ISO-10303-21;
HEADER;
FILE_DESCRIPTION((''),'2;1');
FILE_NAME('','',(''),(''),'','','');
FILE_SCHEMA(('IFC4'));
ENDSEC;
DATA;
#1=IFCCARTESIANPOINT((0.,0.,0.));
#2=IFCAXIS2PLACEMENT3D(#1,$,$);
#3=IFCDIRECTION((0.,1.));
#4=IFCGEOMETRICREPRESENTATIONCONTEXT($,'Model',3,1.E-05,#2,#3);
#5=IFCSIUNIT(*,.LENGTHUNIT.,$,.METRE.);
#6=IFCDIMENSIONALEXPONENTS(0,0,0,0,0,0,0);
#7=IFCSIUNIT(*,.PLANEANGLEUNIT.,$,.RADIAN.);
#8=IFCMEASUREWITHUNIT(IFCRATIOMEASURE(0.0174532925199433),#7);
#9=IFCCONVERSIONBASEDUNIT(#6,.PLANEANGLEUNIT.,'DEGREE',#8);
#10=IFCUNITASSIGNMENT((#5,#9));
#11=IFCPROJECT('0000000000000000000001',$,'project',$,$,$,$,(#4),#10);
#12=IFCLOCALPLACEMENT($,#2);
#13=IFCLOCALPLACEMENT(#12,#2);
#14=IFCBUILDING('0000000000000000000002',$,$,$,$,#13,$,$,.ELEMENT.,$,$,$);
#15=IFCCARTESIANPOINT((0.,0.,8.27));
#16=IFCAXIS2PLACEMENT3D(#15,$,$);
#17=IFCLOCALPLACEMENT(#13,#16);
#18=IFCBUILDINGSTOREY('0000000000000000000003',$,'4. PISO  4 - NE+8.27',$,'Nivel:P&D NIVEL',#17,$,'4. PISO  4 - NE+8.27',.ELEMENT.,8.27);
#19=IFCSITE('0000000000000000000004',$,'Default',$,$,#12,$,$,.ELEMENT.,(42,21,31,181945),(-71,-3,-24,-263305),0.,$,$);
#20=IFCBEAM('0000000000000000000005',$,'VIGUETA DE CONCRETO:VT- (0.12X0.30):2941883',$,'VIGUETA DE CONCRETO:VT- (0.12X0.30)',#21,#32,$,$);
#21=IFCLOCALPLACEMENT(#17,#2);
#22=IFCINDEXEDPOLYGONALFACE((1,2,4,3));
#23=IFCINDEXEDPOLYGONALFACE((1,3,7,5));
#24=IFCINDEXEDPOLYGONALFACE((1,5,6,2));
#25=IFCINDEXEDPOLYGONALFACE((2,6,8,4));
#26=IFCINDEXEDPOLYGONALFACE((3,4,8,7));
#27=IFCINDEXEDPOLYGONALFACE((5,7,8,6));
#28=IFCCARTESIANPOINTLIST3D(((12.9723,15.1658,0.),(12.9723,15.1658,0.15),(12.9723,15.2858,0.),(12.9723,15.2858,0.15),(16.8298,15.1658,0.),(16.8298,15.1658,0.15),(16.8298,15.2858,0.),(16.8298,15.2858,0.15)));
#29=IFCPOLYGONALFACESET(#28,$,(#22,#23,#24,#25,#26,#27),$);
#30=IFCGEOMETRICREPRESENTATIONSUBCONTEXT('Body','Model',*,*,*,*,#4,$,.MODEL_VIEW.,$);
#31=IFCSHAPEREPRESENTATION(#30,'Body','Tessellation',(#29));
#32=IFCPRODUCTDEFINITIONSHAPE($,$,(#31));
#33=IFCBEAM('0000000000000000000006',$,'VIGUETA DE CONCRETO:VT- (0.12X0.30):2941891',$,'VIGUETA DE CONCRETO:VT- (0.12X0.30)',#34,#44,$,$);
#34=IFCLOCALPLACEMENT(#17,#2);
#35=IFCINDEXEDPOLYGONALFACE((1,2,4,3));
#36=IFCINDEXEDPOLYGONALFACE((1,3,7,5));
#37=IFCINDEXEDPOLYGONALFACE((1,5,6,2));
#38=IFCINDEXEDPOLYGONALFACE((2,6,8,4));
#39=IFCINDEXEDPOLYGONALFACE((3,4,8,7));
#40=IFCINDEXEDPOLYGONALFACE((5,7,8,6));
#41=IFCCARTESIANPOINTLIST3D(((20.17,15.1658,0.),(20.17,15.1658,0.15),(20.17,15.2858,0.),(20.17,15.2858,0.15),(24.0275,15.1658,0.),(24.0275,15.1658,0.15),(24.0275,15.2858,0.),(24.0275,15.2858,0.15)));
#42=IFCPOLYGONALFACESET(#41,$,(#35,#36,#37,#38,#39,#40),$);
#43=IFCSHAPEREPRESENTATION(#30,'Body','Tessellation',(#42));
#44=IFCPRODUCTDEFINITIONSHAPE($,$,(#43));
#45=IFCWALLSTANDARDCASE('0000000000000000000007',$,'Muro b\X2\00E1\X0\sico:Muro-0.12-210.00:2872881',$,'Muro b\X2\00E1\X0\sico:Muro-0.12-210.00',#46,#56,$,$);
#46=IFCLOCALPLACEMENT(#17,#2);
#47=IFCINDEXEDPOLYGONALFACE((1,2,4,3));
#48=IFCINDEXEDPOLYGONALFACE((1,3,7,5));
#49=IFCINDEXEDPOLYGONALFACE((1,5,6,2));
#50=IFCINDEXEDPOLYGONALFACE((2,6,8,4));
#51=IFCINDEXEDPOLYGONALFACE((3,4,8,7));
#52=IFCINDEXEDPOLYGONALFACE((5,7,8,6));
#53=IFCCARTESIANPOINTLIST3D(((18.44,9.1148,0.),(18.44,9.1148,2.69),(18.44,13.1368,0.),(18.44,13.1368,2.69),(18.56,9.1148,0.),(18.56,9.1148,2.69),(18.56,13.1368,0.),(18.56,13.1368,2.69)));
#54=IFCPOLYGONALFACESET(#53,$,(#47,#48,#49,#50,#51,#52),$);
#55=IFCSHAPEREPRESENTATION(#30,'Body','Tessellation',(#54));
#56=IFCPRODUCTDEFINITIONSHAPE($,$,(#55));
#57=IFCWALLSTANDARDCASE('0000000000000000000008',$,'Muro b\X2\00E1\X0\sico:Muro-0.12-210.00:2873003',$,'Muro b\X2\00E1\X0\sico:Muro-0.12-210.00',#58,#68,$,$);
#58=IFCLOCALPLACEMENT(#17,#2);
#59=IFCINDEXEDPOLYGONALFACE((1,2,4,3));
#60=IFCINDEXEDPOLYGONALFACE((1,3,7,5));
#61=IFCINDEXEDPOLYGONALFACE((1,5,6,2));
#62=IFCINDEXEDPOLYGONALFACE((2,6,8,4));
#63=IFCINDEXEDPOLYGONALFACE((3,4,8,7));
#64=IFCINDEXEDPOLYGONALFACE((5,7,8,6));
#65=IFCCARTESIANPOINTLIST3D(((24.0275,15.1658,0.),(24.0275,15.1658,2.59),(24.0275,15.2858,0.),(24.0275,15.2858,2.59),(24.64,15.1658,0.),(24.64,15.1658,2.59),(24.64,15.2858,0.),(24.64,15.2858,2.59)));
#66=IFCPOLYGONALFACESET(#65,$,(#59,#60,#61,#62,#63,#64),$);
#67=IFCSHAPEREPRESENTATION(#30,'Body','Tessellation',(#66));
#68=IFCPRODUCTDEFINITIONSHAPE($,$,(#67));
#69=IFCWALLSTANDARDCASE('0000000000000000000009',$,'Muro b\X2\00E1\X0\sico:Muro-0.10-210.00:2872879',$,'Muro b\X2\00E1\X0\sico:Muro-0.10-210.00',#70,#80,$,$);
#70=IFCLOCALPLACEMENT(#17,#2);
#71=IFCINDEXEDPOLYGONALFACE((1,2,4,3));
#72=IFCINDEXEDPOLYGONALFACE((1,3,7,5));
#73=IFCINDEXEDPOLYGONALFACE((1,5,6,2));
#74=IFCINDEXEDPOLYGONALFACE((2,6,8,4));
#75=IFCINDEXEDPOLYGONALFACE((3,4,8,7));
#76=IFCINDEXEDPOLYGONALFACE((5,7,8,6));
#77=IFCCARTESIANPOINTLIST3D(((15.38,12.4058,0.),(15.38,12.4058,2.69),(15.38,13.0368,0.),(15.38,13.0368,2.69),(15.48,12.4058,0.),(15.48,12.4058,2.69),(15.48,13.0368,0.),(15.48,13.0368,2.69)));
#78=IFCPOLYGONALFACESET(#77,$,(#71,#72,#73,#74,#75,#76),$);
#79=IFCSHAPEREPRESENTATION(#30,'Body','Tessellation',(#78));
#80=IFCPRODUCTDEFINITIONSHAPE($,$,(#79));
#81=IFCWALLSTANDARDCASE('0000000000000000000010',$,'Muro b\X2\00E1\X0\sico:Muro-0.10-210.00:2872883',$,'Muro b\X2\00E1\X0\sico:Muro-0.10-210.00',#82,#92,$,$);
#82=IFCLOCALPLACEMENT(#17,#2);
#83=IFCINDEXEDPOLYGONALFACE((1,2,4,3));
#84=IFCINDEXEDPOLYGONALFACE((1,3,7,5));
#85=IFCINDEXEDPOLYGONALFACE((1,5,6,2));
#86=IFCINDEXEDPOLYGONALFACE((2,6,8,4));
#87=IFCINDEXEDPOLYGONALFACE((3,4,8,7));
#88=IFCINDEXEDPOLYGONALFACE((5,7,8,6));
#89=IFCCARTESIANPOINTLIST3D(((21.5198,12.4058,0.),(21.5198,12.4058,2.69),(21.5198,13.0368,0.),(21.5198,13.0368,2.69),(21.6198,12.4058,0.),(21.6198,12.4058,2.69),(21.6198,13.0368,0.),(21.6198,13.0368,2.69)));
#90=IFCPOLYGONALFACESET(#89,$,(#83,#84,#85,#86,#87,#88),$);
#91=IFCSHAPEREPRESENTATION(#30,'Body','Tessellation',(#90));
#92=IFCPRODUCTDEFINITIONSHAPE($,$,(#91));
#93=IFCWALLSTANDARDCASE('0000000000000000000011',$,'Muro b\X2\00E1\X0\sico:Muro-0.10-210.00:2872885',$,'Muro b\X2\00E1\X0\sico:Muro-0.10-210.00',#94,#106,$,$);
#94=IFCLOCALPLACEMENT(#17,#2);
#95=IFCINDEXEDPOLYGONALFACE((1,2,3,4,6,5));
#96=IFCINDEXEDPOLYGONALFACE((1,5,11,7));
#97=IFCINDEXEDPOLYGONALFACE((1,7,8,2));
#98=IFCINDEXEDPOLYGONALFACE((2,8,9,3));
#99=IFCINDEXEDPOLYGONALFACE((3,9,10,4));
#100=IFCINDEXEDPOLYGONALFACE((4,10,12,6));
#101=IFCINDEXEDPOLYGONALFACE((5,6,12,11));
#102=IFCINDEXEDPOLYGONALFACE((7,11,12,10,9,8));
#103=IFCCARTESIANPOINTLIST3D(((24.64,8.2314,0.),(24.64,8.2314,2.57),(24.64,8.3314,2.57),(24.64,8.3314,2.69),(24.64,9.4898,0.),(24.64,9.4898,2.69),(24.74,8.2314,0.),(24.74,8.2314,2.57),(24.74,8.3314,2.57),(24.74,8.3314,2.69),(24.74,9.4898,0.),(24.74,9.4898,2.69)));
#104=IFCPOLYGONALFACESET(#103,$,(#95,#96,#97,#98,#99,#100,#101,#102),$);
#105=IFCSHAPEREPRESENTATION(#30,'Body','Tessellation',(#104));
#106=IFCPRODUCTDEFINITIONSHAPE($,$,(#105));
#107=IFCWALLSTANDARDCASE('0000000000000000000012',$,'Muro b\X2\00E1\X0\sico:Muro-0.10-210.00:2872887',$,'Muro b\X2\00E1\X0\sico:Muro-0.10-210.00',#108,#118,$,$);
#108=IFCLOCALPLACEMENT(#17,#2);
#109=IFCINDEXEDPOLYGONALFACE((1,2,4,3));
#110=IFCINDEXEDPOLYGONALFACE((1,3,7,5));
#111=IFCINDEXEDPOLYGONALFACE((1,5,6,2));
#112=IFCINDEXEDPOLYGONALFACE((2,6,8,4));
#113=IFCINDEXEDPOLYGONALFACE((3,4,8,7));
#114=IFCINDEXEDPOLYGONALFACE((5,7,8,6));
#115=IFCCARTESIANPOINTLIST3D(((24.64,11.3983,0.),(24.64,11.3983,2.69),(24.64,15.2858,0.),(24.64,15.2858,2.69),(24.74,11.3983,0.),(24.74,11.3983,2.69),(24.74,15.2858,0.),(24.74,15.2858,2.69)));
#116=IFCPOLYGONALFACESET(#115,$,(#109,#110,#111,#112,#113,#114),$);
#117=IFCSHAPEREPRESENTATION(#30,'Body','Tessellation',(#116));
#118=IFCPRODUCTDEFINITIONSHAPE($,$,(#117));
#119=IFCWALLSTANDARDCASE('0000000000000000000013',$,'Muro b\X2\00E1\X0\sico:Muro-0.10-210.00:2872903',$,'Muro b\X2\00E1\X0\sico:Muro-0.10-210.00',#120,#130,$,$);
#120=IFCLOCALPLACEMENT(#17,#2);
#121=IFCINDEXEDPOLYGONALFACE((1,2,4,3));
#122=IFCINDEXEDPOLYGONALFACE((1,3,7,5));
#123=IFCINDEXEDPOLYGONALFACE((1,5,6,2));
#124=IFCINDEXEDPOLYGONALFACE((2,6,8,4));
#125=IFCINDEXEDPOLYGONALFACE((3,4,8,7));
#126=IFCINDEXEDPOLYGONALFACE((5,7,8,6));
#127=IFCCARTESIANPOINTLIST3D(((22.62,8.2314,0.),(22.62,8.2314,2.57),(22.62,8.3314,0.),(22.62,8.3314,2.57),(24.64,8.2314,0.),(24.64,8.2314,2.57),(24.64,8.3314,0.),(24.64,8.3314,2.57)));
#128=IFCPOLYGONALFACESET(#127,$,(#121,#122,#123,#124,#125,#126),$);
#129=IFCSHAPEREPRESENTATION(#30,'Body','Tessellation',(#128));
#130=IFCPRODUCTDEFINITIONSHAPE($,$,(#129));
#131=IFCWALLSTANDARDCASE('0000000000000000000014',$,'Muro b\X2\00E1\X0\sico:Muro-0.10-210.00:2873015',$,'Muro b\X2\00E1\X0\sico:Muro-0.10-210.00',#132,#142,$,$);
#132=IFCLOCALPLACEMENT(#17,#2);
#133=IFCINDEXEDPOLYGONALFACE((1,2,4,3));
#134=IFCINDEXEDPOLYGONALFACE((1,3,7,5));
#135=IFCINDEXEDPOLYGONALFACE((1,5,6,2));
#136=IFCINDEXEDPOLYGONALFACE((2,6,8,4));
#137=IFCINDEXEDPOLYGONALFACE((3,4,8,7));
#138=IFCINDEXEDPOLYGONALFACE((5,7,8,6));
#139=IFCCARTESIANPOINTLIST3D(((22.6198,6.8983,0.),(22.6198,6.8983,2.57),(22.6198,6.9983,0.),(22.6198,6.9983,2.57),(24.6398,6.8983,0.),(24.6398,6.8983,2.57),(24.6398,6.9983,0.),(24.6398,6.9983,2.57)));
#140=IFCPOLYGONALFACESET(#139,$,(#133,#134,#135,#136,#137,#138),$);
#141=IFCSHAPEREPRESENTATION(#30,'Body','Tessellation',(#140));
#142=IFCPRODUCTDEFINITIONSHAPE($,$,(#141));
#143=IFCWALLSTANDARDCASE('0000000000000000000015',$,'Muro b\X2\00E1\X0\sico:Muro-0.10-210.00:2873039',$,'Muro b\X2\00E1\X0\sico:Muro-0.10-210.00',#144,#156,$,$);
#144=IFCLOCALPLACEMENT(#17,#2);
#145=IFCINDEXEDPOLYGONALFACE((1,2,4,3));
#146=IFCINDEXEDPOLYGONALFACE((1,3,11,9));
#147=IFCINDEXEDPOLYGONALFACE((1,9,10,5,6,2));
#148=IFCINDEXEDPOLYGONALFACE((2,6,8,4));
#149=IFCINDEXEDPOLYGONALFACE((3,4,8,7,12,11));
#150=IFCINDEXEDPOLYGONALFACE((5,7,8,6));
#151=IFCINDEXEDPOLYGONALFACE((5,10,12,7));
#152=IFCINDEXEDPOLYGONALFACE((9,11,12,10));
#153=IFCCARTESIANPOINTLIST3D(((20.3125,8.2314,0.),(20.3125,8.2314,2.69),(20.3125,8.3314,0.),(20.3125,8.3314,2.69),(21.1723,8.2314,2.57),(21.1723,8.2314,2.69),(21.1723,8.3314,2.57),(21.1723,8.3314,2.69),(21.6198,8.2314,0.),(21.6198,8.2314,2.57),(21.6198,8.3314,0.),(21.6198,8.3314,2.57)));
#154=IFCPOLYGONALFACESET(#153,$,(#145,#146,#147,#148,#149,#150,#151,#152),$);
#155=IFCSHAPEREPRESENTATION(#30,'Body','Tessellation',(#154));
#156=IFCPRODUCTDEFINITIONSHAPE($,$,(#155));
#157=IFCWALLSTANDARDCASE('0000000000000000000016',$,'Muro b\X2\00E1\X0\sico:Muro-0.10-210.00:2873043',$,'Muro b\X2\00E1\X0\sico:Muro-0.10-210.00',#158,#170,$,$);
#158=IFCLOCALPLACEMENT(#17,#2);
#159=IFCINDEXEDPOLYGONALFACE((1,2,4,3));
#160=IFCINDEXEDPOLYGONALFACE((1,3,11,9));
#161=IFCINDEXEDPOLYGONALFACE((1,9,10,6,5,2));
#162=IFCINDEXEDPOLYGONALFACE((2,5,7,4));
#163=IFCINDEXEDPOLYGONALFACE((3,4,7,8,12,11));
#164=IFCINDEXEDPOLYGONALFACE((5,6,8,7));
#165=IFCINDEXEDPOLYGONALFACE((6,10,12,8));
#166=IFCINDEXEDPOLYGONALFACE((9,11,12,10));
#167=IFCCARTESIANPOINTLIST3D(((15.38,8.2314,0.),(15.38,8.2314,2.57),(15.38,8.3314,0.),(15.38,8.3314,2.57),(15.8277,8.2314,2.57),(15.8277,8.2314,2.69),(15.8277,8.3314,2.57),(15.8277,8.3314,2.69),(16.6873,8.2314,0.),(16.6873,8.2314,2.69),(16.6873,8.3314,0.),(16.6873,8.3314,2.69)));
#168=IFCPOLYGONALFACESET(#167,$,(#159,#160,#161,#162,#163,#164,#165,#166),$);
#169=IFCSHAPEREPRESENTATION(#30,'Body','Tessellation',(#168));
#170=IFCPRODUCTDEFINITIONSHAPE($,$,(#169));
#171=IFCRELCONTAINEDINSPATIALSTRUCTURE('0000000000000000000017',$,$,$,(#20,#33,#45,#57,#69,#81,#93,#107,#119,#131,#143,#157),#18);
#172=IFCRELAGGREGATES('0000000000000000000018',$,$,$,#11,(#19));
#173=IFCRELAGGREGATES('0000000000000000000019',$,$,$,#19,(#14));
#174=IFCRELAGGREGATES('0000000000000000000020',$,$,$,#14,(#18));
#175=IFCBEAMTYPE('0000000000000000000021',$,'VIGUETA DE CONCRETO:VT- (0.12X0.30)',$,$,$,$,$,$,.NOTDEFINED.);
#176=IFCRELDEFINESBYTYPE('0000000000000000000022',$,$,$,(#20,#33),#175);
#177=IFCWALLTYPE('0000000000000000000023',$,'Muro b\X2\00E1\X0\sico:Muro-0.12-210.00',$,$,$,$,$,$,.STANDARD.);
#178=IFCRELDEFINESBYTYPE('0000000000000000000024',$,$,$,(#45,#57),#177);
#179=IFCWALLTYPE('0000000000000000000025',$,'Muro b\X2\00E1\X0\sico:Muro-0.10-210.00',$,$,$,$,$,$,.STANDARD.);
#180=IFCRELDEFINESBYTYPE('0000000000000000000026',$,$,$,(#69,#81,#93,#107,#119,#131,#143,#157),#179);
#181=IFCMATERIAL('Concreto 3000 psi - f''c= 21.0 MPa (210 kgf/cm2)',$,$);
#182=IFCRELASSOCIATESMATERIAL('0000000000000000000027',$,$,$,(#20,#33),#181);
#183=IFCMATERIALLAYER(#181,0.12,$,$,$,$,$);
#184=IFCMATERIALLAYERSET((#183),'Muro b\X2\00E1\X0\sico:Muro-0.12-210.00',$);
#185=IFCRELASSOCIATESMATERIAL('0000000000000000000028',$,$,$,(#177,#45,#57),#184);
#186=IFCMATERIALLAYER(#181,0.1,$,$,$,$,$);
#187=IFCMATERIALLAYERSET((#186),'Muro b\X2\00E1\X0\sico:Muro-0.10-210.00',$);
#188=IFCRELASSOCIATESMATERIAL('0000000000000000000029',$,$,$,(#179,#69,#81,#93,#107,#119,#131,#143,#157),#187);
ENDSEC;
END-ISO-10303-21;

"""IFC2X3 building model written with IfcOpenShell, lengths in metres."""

from ifc_helpers import new_model, entity, si_unit, converted_unit, direction, frame, frame_2d, origin, place, context, subcontext, project, spatial, polyline, rectangle, extrude, clip, bounded_halfspace, material, layer, layer_set, layer_usage, type_object, element, save


model = new_model("IFC2X3")

# Units and contexts
model_context = context("Model", 3, precision=1e-05, world=origin(), true_north=direction((0.0, 1.0)))
body_context = subcontext(model_context, "Body", "Model", "MODEL_VIEW")
ifc_project = project(units=[si_unit("LENGTHUNIT", "METRE"), converted_unit("PLANEANGLEUNIT", "DEGREE", entity("IfcRatioMeasure", 0.0174532925199433), si_unit("PLANEANGLEUNIT", "RADIAN"), dimensions=[0, 0, 0, 0, 0, 0, 0])], contexts=[model_context])

# Site, building, storey
site_placement = place(None, origin())
site = spatial("IfcSite", under=ifc_project, at=site_placement, Name="Default", CompositionType="ELEMENT", RefLatitude=(42, 21, 31, 181945), RefLongitude=(-71, -3, -24, -263305), RefElevation=0.0)
building_placement = place(site_placement, origin())
building = spatial("IfcBuilding", under=site, at=building_placement, CompositionType="ELEMENT")
storey_placement = place(building_placement, frame((0.0, 0.0, 8.27)))
storey = spatial("IfcBuildingStorey", under=building, at=storey_placement, Name="4. PISO  4 - NE+8.27", ObjectType="Nivel:P&D NIVEL", LongName="4. PISO  4 - NE+8.27", CompositionType="ELEMENT", Elevation=8.27)

# Beams
ifc_material = material(Name="Concreto 3000 psi - f'c= 21.0 MPa (210 kgf/cm2)")
beam_type_1 = type_object("IfcBeamType", Name="VIGUETA DE CONCRETO:VT- (0.12X0.30)", PredefinedType="NOTDEFINED")
beam_1_placement = place(storey_placement, frame((16.9048, 15.2258, 0.0), z_axis=(0.0, 0.0, 1.0), x_axis=(-1.0, 0.0, 0.0)))
element("IfcBeam", 1, at=beam_1_placement, inside=storey, type_object=beam_type_1, material=ifc_material, Name="VIGUETA DE CONCRETO:VT- (0.12X0.30):2941883", ObjectType="VIGUETA DE CONCRETO:VT- (0.12X0.30)", context=body_context, shape_type="SweptSolid", body=[
    extrude(rectangle(XDim=0.15, YDim=0.12, at=frame_2d((0.0, 0.0), x_axis=(1.0, 0.0))), frame((0.075, 0.0, 0.075), z_axis=(1.0, 0.0, 0.0), x_axis=(0.0, 0.0, -1.0)), (0.0, 0.0, 1.0), 3.8575),
])
beam_2_placement = place(storey_placement, frame((20.095, 15.2258, 0.0)))
element("IfcBeam", 2, at=beam_2_placement, inside=storey, type_object=beam_type_1, material=ifc_material, Name="VIGUETA DE CONCRETO:VT- (0.12X0.30):2941891", ObjectType="VIGUETA DE CONCRETO:VT- (0.12X0.30)", context=body_context, shape_type="SweptSolid", body=[
    extrude(rectangle(XDim=0.15, YDim=0.12, at=frame_2d((0.0, 0.0), x_axis=(1.0, 0.0))), frame((0.075, 0.0, 0.075), z_axis=(1.0, 0.0, 0.0), x_axis=(0.0, 0.0, -1.0)), (0.0, 0.0, 1.0), 3.8575),
])

# Walls
ifc_layer_1 = layer(ifc_material, 0.12)
ifc_layer_set_1 = layer_set([ifc_layer_1], Name="Muro básico:Muro-0.12-210.00")
ifc_layer_usage_1 = layer_usage(ifc_layer_set_1, "AXIS2", "POSITIVE", -0.06)
wall_type_1 = type_object("IfcWallType", Name="Muro básico:Muro-0.12-210.00", PredefinedType="STANDARD", material=ifc_layer_set_1)
wall_1_placement = place(storey_placement, frame((18.5, 9.1148, 0.0), z_axis=(0.0, 0.0, 1.0), x_axis=(0.0, 1.0, 0.0)))
element("IfcWallStandardCase", 3, at=wall_1_placement, inside=storey, type_object=wall_type_1, material=ifc_layer_usage_1, Name="Muro básico:Muro-0.12-210.00:2872881", ObjectType="Muro básico:Muro-0.12-210.00", context=body_context, shape_type="SweptSolid", body=[
    extrude(rectangle(XDim=4.022, YDim=0.12, at=frame_2d((2.011, 0.0), x_axis=(-1.0, 0.0))), origin(), (0.0, 0.0, 1.0), 2.69),
])
wall_2_placement = place(storey_placement, frame((24.0275, 15.2258, 0.0)))
element("IfcWallStandardCase", 4, at=wall_2_placement, inside=storey, type_object=wall_type_1, material=ifc_layer_usage_1, Name="Muro básico:Muro-0.12-210.00:2873003", ObjectType="Muro básico:Muro-0.12-210.00", context=body_context, shape_type="SweptSolid", body=[
    extrude(rectangle(XDim=0.6125, YDim=0.12, at=frame_2d((0.3062, 0.0), x_axis=(-1.0, 0.0))), origin(), (0.0, 0.0, 1.0), 2.59),
])
ifc_layer_2 = layer(ifc_material, 0.1)
ifc_layer_set_2 = layer_set([ifc_layer_2], Name="Muro básico:Muro-0.10-210.00")
ifc_layer_usage_2 = layer_usage(ifc_layer_set_2, "AXIS2", "POSITIVE", -0.05)
wall_type_2 = type_object("IfcWallType", Name="Muro básico:Muro-0.10-210.00", PredefinedType="STANDARD", material=ifc_layer_set_2)
wall_3_placement = place(storey_placement, frame((15.43, 12.4058, 0.0), z_axis=(0.0, 0.0, 1.0), x_axis=(0.0, 1.0, 0.0)))
element("IfcWallStandardCase", 5, at=wall_3_placement, inside=storey, type_object=wall_type_2, material=ifc_layer_usage_2, Name="Muro básico:Muro-0.10-210.00:2872879", ObjectType="Muro básico:Muro-0.10-210.00", context=body_context, shape_type="SweptSolid", body=[
    extrude(rectangle(XDim=0.631, YDim=0.1, at=frame_2d((0.3155, 0.0), x_axis=(-1.0, 0.0))), origin(), (0.0, 0.0, 1.0), 2.69),
])
wall_4_placement = place(storey_placement, frame((21.5698, 12.4058, 0.0), z_axis=(0.0, 0.0, 1.0), x_axis=(0.0, 1.0, 0.0)))
element("IfcWallStandardCase", 6, at=wall_4_placement, inside=storey, type_object=wall_type_2, material=ifc_layer_usage_2, Name="Muro básico:Muro-0.10-210.00:2872883", ObjectType="Muro básico:Muro-0.10-210.00", context=body_context, shape_type="SweptSolid", body=[
    extrude(rectangle(XDim=0.631, YDim=0.1, at=frame_2d((0.3155, 0.0), x_axis=(-1.0, 0.0))), origin(), (0.0, 0.0, 1.0), 2.69),
])
wall_5_placement = place(storey_placement, frame((24.69, 8.2314, 0.0), z_axis=(0.0, 0.0, 1.0), x_axis=(0.0, 1.0, 0.0)))
element("IfcWallStandardCase", 7, at=wall_5_placement, inside=storey, type_object=wall_type_2, material=ifc_layer_usage_2, Name="Muro básico:Muro-0.10-210.00:2872885", ObjectType="Muro básico:Muro-0.10-210.00", context=body_context, shape_type="Clipping", body=[
    clip(clip(extrude(rectangle(XDim=1.2584, YDim=0.1, at=frame_2d((0.6292, 0.0), x_axis=(-1.0, 0.0))), origin(), (0.0, 0.0, 1.0), 2.69), bounded_halfspace(frame((0.1, -0.05, 2.57), z_axis=(0.0, 0.0, -1.0), x_axis=(-1.0, 0.0, 0.0)), True, frame((0.1, -0.05, 2.57), z_axis=(0.0, 0.0, -1.0), x_axis=(-1.0, 0.0, 0.0)), polyline([(0.0, 0.0), (0.1, 0.0), (0.1, 0.1), (0.0, 0.1), (0.0, 0.0)]))), bounded_halfspace(frame((0.1, 0.05, 2.57), z_axis=(1.0, 0.0, 0.0), x_axis=(0.0, 0.0, 1.0)), True, frame((0.1, 0.05, 2.57), z_axis=(1.0, 0.0, 0.0), x_axis=(0.0, 0.0, 1.0)), polyline([(0.0, 0.0), (0.12, 0.0), (0.12, 0.1), (0.0, 0.1), (0.0, 0.0)]))),
])
wall_6_placement = place(storey_placement, frame((24.69, 11.3983, 0.0), z_axis=(0.0, 0.0, 1.0), x_axis=(0.0, 1.0, 0.0)))
element("IfcWallStandardCase", 8, at=wall_6_placement, inside=storey, type_object=wall_type_2, material=ifc_layer_usage_2, Name="Muro básico:Muro-0.10-210.00:2872887", ObjectType="Muro básico:Muro-0.10-210.00", context=body_context, shape_type="SweptSolid", body=[
    extrude(rectangle(XDim=3.8875, YDim=0.1, at=frame_2d((1.9437, 0.0), x_axis=(-1.0, 0.0))), origin(), (0.0, 0.0, 1.0), 2.69),
])
wall_7_placement = place(storey_placement, frame((22.62, 8.2814, 0.0)))
element("IfcWallStandardCase", 9, at=wall_7_placement, inside=storey, type_object=wall_type_2, material=ifc_layer_usage_2, Name="Muro básico:Muro-0.10-210.00:2872903", ObjectType="Muro básico:Muro-0.10-210.00", context=body_context, shape_type="Clipping", body=[
    clip(extrude(rectangle(XDim=2.02, YDim=0.1, at=frame_2d((1.01, 0.0), x_axis=(-1.0, 0.0))), origin(), (0.0, 0.0, 1.0), 2.57), bounded_halfspace(frame((0.0, -0.05, 2.57), z_axis=(0.0, 0.0, -1.0), x_axis=(0.0, -1.0, 0.0)), True, frame((0.0, -0.05, 2.57), z_axis=(0.0, 0.0, -1.0), x_axis=(0.0, -1.0, 0.0)), polyline([(0.0, 0.0), (-0.1, 0.0), (-0.1, -2.02), (0.0, -2.02), (0.0, 0.0)]))),
])
wall_8_placement = place(storey_placement, frame((22.6198, 6.9483, 0.0)))
element("IfcWallStandardCase", 10, at=wall_8_placement, inside=storey, type_object=wall_type_2, material=ifc_layer_usage_2, Name="Muro básico:Muro-0.10-210.00:2873015", ObjectType="Muro básico:Muro-0.10-210.00", context=body_context, shape_type="Clipping", body=[
    clip(extrude(rectangle(XDim=2.02, YDim=0.1, at=frame_2d((1.01, 0.0), x_axis=(-1.0, 0.0))), origin(), (0.0, 0.0, 1.0), 2.57), bounded_halfspace(frame((0.0, -0.05, 2.57), z_axis=(0.0, 0.0, -1.0), x_axis=(0.0, -1.0, 0.0)), True, frame((0.0, -0.05, 2.57), z_axis=(0.0, 0.0, -1.0), x_axis=(0.0, -1.0, 0.0)), polyline([(0.0, 0.0), (-0.1, 0.0), (-0.1, -2.02), (0.0, -2.02), (0.0, 0.0)]))),
])
wall_9_placement = place(storey_placement, frame((20.3125, 8.2814, 0.0)))
element("IfcWallStandardCase", 11, at=wall_9_placement, inside=storey, type_object=wall_type_2, material=ifc_layer_usage_2, Name="Muro básico:Muro-0.10-210.00:2873039", ObjectType="Muro básico:Muro-0.10-210.00", context=body_context, shape_type="Clipping", body=[
    clip(clip(extrude(rectangle(XDim=1.3073, YDim=0.1, at=frame_2d((0.6536, 0.0), x_axis=(-1.0, 0.0))), origin(), (0.0, 0.0, 1.0), 2.69), bounded_halfspace(frame((0.8598, 0.05, 2.57), z_axis=(0.0, 0.0, -1.0), x_axis=(0.0, -1.0, 0.0)), True, frame((0.8598, 0.05, 2.57), z_axis=(0.0, 0.0, -1.0), x_axis=(0.0, -1.0, 0.0)), polyline([(0.0, 0.0), (0.0, -0.4475), (0.1, -0.4475), (0.1, 0.0), (0.0, 0.0)]))), bounded_halfspace(frame((0.8598, -0.05, 2.57), z_axis=(-1.0, 0.0, 0.0), x_axis=(0.0, 0.0, 1.0)), True, frame((0.8598, -0.05, 2.57), z_axis=(-1.0, 0.0, 0.0), x_axis=(0.0, 0.0, 1.0)), polyline([(0.0, 0.0), (0.12, 0.0), (0.12, 0.1), (0.0, 0.1), (0.0, 0.0)]))),
])
wall_10_placement = place(storey_placement, frame((15.38, 8.2814, 0.0)))
element("IfcWallStandardCase", 12, at=wall_10_placement, inside=storey, type_object=wall_type_2, material=ifc_layer_usage_2, Name="Muro básico:Muro-0.10-210.00:2873043", ObjectType="Muro básico:Muro-0.10-210.00", context=body_context, shape_type="Clipping", body=[
    clip(clip(extrude(rectangle(XDim=1.3073, YDim=0.1, at=frame_2d((0.6536, 0.0), x_axis=(-1.0, 0.0))), origin(), (0.0, 0.0, 1.0), 2.69), bounded_halfspace(frame((0.4477, -0.05, 2.57), z_axis=(0.0, 0.0, -1.0), x_axis=(0.0, -1.0, 0.0)), True, frame((0.4477, -0.05, 2.57), z_axis=(0.0, 0.0, -1.0), x_axis=(0.0, -1.0, 0.0)), polyline([(0.0, 0.0), (0.0, 0.4477), (-0.1, 0.4477), (-0.1, 0.0), (0.0, 0.0)]))), bounded_halfspace(frame((0.4477, 0.05, 2.57), z_axis=(1.0, 0.0, 0.0), x_axis=(0.0, 0.0, 1.0)), True, frame((0.4477, 0.05, 2.57), z_axis=(1.0, 0.0, 0.0), x_axis=(0.0, 0.0, 1.0)), polyline([(0.0, 0.0), (0.12, 0.0), (0.12, 0.1), (0.0, 0.1), (0.0, 0.0)]))),
])

save(model, "model.ifc")
